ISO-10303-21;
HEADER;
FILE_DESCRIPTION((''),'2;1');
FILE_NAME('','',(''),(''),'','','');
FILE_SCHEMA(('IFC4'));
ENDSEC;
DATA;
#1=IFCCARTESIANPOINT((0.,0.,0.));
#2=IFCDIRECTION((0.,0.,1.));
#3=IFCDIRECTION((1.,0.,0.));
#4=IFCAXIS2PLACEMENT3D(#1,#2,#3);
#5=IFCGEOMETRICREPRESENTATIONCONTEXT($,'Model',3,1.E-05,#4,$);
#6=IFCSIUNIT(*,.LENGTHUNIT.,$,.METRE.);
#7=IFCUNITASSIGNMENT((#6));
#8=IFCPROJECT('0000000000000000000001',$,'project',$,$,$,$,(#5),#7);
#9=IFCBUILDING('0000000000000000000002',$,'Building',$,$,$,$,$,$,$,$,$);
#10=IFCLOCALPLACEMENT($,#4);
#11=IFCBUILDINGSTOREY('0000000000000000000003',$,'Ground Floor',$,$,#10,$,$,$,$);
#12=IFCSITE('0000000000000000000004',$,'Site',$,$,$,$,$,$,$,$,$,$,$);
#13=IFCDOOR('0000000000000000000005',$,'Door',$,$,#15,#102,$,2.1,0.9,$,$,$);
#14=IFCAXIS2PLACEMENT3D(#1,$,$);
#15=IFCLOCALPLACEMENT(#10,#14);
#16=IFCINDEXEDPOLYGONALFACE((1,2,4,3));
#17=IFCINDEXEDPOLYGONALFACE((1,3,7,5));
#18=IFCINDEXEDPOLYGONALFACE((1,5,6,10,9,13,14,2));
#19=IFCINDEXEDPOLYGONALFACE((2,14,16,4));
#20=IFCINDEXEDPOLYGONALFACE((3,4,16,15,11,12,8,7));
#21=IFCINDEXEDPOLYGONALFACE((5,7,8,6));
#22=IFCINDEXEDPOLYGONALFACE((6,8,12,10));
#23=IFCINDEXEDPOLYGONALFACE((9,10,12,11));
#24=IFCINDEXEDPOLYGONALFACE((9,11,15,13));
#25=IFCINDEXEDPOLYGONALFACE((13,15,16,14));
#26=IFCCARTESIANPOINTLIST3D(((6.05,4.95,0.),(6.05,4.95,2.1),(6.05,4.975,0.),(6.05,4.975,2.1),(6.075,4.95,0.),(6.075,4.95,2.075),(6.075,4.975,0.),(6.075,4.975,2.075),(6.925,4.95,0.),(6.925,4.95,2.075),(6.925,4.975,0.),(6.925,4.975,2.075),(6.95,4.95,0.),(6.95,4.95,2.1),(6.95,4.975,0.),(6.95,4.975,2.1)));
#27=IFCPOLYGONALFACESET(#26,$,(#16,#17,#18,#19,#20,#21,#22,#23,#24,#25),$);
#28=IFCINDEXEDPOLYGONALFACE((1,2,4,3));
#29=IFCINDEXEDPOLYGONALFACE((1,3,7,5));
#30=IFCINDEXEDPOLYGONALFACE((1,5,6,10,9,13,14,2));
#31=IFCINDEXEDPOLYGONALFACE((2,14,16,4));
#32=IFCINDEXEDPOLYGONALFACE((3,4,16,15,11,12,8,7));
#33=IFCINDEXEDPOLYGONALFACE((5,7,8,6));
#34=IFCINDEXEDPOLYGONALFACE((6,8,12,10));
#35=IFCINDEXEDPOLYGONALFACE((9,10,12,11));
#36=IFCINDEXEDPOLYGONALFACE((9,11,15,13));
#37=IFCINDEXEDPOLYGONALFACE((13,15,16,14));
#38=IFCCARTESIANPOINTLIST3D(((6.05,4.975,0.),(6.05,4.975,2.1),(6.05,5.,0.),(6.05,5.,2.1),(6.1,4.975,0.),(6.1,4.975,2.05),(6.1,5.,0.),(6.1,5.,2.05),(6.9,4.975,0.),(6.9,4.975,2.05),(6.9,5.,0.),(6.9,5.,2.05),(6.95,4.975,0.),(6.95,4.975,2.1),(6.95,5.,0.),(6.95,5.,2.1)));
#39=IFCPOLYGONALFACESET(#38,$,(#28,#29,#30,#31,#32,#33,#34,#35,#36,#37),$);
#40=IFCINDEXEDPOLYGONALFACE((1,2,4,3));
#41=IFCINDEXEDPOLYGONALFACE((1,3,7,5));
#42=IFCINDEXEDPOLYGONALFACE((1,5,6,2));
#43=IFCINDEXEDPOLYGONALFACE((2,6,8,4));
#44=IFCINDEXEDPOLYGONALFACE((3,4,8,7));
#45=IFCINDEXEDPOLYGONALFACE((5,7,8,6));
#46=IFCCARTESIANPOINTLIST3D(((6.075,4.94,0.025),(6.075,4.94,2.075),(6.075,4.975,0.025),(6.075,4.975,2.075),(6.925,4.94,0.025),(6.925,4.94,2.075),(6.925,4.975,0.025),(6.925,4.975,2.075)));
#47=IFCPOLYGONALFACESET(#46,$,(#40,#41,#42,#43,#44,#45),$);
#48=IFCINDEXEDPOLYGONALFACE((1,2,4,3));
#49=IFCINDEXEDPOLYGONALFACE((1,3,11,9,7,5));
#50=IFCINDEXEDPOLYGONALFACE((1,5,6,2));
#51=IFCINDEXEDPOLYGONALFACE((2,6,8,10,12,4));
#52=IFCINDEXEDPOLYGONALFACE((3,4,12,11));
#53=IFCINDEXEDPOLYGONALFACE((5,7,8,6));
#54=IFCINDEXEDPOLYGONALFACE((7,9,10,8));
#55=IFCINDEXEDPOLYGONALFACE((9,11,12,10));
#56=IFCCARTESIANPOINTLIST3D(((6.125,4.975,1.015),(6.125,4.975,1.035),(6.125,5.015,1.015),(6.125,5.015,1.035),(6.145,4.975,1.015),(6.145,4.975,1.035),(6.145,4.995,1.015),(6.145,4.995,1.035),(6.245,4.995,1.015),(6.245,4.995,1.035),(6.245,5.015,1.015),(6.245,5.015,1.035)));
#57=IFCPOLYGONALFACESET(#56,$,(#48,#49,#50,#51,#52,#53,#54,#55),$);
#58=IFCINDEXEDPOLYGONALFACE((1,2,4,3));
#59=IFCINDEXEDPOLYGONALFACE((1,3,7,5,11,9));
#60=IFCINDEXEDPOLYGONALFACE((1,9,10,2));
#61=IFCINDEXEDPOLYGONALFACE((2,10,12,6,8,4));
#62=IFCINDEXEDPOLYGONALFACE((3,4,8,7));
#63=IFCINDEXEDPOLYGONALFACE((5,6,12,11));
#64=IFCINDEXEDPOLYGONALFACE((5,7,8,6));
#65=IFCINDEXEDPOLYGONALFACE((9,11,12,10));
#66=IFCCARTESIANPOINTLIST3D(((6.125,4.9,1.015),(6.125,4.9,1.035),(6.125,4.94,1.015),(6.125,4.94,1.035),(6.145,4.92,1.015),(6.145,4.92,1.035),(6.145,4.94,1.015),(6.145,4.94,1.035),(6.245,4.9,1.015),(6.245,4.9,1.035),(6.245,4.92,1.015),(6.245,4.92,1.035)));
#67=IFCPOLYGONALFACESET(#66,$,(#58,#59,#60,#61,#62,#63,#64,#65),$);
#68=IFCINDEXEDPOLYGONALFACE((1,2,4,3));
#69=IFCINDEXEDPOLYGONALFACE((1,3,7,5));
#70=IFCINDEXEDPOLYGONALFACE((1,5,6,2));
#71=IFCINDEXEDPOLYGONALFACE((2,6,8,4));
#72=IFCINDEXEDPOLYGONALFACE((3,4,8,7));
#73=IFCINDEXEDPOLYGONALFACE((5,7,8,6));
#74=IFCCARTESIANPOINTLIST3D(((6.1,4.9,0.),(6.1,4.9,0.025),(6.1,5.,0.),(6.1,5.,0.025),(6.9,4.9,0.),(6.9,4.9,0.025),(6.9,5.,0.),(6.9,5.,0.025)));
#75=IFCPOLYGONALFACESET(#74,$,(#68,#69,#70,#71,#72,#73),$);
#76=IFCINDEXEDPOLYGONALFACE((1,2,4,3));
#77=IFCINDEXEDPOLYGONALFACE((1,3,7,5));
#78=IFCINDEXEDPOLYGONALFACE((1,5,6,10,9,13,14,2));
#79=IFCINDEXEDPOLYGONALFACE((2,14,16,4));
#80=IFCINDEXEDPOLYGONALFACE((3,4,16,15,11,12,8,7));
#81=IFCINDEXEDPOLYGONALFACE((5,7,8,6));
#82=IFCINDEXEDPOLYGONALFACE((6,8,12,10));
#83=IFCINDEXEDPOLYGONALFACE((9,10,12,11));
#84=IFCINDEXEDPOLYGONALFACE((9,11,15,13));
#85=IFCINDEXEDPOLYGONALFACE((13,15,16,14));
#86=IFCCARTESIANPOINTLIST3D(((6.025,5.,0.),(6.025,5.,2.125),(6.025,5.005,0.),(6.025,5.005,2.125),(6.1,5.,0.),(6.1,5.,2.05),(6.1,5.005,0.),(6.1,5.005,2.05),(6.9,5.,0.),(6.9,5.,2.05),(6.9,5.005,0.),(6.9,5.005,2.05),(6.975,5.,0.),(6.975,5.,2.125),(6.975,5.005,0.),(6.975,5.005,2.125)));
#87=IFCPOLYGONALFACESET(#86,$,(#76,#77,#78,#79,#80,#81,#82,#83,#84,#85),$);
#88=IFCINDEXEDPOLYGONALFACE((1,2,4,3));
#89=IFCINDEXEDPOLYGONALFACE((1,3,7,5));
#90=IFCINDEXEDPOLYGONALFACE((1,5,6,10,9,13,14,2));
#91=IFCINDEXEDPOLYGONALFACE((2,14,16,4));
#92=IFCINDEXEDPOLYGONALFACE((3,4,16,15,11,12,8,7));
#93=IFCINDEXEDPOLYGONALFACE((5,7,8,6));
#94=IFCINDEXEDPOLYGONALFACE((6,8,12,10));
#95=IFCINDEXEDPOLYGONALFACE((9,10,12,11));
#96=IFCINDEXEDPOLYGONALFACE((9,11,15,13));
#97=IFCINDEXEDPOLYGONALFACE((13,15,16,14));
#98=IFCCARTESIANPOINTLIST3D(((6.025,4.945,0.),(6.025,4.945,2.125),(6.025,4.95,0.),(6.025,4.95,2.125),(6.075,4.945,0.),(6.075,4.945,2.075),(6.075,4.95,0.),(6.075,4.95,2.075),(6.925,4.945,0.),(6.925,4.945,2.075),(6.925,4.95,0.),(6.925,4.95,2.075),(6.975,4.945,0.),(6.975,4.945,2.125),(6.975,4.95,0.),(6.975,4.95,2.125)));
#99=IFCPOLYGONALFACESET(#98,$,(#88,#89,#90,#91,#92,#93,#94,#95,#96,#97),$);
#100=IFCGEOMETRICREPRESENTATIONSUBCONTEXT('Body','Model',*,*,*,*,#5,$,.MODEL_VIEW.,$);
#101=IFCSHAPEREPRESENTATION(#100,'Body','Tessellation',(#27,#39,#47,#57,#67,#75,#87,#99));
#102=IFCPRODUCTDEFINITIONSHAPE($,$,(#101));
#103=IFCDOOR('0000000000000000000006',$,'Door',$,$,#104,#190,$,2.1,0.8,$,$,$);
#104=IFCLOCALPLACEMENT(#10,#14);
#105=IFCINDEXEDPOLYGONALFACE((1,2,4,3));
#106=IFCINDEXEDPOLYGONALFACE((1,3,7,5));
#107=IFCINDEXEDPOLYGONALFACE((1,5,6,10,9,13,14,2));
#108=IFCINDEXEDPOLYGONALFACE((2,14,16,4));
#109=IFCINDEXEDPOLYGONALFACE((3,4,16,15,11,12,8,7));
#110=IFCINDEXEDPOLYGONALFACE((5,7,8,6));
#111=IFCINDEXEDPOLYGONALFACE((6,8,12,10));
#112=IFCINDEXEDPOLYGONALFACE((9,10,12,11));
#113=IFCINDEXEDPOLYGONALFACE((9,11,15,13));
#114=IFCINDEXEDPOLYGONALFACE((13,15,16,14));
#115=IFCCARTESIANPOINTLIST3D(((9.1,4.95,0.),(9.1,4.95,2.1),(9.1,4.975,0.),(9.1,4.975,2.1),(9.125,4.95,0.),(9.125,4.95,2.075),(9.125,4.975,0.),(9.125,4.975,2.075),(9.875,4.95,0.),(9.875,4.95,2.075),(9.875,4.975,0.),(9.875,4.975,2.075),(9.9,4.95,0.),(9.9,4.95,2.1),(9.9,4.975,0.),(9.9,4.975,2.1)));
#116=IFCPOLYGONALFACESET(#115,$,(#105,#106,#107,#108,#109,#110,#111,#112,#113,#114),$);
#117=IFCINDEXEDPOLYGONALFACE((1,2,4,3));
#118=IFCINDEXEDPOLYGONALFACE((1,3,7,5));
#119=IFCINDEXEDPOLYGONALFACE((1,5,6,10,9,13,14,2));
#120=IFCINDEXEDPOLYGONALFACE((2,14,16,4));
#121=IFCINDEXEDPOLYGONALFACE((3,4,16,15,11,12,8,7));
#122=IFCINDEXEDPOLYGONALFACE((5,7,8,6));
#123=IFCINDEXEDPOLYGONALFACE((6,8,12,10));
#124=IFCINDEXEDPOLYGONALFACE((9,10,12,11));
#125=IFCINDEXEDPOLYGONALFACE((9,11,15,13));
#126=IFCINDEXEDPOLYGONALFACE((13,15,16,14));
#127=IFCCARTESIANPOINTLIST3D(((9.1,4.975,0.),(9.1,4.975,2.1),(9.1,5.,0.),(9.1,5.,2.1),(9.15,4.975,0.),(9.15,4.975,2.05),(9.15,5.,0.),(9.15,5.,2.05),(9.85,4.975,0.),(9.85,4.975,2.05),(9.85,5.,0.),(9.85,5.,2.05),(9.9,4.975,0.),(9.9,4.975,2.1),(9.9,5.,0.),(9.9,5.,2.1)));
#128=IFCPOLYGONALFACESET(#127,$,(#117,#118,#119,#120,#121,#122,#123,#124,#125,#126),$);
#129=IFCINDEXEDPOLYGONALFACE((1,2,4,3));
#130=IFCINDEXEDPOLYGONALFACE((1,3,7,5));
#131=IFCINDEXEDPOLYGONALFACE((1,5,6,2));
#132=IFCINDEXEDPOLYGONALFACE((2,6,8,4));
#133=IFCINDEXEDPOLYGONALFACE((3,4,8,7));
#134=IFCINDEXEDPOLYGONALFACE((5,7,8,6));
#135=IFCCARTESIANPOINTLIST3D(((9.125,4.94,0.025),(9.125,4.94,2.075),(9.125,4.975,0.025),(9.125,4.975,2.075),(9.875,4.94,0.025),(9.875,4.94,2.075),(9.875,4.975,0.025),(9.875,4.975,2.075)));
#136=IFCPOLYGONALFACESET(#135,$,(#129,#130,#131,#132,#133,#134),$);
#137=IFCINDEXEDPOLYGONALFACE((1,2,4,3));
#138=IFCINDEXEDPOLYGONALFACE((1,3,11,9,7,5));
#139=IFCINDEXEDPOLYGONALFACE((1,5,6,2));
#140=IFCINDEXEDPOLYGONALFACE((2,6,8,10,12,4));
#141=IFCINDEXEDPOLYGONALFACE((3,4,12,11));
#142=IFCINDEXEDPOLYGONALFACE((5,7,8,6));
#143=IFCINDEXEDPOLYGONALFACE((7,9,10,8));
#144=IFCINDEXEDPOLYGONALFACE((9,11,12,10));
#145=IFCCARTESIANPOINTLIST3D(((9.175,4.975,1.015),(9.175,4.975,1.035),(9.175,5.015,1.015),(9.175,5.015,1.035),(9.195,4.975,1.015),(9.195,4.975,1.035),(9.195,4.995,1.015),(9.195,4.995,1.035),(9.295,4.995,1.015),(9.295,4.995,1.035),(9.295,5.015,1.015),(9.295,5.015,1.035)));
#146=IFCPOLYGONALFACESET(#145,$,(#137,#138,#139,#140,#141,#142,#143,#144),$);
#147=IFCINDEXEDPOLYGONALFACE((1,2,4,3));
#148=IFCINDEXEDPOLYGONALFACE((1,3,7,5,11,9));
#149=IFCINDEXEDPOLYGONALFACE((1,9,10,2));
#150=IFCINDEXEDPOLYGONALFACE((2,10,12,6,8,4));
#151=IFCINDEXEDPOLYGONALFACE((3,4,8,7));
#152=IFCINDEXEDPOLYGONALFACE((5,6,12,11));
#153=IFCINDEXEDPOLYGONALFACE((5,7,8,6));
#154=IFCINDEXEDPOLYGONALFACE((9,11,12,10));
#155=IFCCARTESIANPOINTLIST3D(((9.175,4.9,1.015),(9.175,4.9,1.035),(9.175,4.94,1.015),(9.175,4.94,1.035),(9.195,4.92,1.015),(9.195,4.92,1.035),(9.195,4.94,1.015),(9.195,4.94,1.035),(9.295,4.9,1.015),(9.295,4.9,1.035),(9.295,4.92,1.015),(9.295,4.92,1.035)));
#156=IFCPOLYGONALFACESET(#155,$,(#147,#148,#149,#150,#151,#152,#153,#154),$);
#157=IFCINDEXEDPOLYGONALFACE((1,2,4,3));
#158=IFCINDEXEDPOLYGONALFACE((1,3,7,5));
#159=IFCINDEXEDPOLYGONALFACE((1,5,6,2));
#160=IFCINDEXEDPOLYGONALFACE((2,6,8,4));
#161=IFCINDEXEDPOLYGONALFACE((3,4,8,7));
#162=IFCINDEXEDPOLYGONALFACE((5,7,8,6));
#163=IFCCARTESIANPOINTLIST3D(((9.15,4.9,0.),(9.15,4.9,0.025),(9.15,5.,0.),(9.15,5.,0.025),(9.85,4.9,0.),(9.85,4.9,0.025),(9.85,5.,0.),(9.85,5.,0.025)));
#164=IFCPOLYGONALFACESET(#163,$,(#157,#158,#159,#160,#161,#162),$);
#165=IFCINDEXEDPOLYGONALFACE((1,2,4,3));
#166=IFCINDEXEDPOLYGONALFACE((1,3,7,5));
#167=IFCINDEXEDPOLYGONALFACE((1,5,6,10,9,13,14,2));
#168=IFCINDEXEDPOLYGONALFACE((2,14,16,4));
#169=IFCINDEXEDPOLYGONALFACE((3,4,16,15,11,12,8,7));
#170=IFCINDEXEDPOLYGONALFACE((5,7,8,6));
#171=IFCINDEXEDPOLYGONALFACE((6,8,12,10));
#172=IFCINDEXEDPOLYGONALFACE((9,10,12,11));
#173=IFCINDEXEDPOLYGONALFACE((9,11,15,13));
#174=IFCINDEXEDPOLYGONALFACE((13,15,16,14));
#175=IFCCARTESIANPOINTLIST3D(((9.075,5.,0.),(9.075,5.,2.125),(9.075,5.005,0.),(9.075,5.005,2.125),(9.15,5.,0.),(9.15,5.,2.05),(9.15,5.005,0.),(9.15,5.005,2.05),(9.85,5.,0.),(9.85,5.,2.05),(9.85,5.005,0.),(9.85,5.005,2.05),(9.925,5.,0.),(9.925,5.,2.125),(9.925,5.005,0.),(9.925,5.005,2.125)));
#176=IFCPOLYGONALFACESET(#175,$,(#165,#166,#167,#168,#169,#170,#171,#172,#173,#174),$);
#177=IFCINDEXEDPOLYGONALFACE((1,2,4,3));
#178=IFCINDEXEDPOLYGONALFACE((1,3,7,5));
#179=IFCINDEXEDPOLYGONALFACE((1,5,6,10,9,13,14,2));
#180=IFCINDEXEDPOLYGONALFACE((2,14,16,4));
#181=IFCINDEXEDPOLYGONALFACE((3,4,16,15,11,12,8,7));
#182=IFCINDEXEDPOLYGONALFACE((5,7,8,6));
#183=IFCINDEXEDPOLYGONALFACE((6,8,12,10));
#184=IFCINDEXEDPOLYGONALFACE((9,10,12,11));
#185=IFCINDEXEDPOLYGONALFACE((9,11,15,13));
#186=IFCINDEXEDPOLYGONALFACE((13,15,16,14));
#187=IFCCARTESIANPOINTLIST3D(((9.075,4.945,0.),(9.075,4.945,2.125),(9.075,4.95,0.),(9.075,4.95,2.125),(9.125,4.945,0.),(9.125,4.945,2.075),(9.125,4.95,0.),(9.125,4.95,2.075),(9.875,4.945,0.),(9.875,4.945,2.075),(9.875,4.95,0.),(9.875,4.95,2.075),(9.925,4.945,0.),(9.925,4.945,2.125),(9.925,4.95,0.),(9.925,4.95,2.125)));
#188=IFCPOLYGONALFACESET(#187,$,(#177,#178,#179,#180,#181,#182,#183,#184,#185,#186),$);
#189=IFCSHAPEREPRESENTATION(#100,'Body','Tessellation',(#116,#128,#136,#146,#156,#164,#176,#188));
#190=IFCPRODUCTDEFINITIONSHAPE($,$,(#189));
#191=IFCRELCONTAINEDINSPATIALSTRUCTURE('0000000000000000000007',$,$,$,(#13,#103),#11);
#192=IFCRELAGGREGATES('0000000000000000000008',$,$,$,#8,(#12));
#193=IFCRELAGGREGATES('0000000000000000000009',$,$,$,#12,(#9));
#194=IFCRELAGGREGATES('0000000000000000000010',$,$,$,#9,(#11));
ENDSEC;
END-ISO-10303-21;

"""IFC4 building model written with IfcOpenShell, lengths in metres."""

from ifc_helpers import new_model, si_unit, frame, origin_with_axes, place, context, subcontext, project, spatial, line, indexed_curve, outline, extrude, element, save


model = new_model("IFC4")

# Units and contexts
model_context = context("Model", 3, precision=1e-05, world=origin_with_axes())
body_context = subcontext(model_context, "Body", "Model", "MODEL_VIEW")
ifc_project = project(units=[si_unit("LENGTHUNIT", "METRE")], contexts=[model_context])

# Site, building, storey
site = spatial("IfcSite", under=ifc_project, Name="Site")
building = spatial("IfcBuilding", under=site, Name="Building")
storey_placement = place(None, origin_with_axes())
storey = spatial("IfcBuildingStorey", under=building, at=storey_placement, Name="Ground Floor")

# Doors
door_1_placement = place(storey_placement, frame((6.95, 5.0, 0.0), z_axis=(0.0, 0.0, 1.0), x_axis=(-1.0, 0.0, 0.0)))
element("IfcDoor", 1, at=door_1_placement, inside=storey, Name="Door", OverallHeight=2.1, OverallWidth=0.9, context=body_context, shape_type="SweptSolid", body=[
    extrude(outline(indexed_curve([(0.0, 0.0), (0.0, 2.1), (0.9, 2.1), (0.9, 0.0), (0.875, 0.0), (0.875, 2.075), (0.025, 2.075), (0.025, 0.0)], segments=[line(1, 2, 3, 4, 5, 6, 7, 8, 1)])), frame((0.0, 0.025, 0.0), z_axis=(0.0, -1.0, 0.0), x_axis=(1.0, 0.0, 0.0)), (0.0, 0.0, -1.0), 0.025),
    extrude(outline(indexed_curve([(0.0, 0.0), (0.0, 2.1), (0.9, 2.1), (0.9, 0.0), (0.85, 0.0), (0.85, 2.05), (0.05, 2.05), (0.05, 0.0)], segments=[line(1, 2, 3, 4, 5, 6, 7, 8, 1)])), frame((0.0, 0.0, 0.0), z_axis=(0.0, -1.0, 0.0), x_axis=(1.0, 0.0, 0.0)), (0.0, 0.0, -1.0), 0.025),
    extrude(outline(indexed_curve([(0.0, 0.0), (0.85, 0.0), (0.85, 0.035), (0.0, 0.035)], segments=[line(1, 2, 3, 4, 1)])), frame((0.025, 0.025, 0.025), z_axis=(0.0, 0.0, 1.0), x_axis=(1.0, 0.0, 0.0)), (0.0, 0.0, 1.0), 2.05),
    extrude(outline(indexed_curve([(0.0, 0.0), (0.0, -0.04), (-0.12, -0.04), (-0.12, -0.02), (-0.02, -0.02), (-0.02, 0.0)], segments=[line(1, 2, 3, 4, 5, 6, 1)])), frame((0.825, 0.025, 1.015), z_axis=(0.0, 0.0, 1.0), x_axis=(1.0, 0.0, 0.0)), (0.0, 0.0, 1.0), 0.02),
    extrude(outline(indexed_curve([(0.0, 0.0), (0.0, 0.04), (-0.12, 0.04), (-0.12, 0.02), (-0.02, 0.02), (-0.02, 0.0)], segments=[line(1, 2, 3, 4, 5, 6, 1)])), frame((0.825, 0.06, 1.015), z_axis=(0.0, 0.0, 1.0), x_axis=(1.0, 0.0, 0.0)), (0.0, 0.0, 1.0), 0.02),
    extrude(outline(indexed_curve([(0.0, 0.0), (0.8, 0.0), (0.8, 0.1), (0.0, 0.1)], segments=[line(1, 2, 3, 4, 1)])), frame((0.05, 0.0, 0.0), z_axis=(0.0, 0.0, 1.0), x_axis=(1.0, 0.0, 0.0)), (0.0, 0.0, 1.0), 0.025),
    extrude(outline(indexed_curve([(0.0, 0.0), (0.0, 2.125), (0.95, 2.125), (0.95, 0.0), (0.875, 0.0), (0.875, 2.05), (0.075, 2.05), (0.075, 0.0)], segments=[line(1, 2, 3, 4, 5, 6, 7, 8, 1)])), frame((-0.025, -0.005, 0.0), z_axis=(0.0, -1.0, 0.0), x_axis=(1.0, 0.0, 0.0)), (0.0, 0.0, -1.0), 0.005),
    extrude(outline(indexed_curve([(0.0, 0.0), (0.0, 2.125), (0.95, 2.125), (0.95, 0.0), (0.9, 0.0), (0.9, 2.075), (0.05, 2.075), (0.05, 0.0)], segments=[line(1, 2, 3, 4, 5, 6, 7, 8, 1)])), frame((-0.025, 0.05, 0.0), z_axis=(0.0, -1.0, 0.0), x_axis=(1.0, 0.0, 0.0)), (0.0, 0.0, -1.0), 0.005),
])
door_2_placement = place(storey_placement, frame((9.9, 5.0, 0.0), z_axis=(0.0, 0.0, 1.0), x_axis=(-1.0, 0.0, 0.0)))
element("IfcDoor", 2, at=door_2_placement, inside=storey, Name="Door", OverallHeight=2.1, OverallWidth=0.8, context=body_context, shape_type="SweptSolid", body=[
    extrude(outline(indexed_curve([(0.0, 0.0), (0.0, 2.1), (0.8, 2.1), (0.8, 0.0), (0.775, 0.0), (0.775, 2.075), (0.025, 2.075), (0.025, 0.0)], segments=[line(1, 2, 3, 4, 5, 6, 7, 8, 1)])), frame((0.0, 0.025, 0.0), z_axis=(0.0, -1.0, 0.0), x_axis=(1.0, 0.0, 0.0)), (0.0, 0.0, -1.0), 0.025),
    extrude(outline(indexed_curve([(0.0, 0.0), (0.0, 2.1), (0.8, 2.1), (0.8, 0.0), (0.75, 0.0), (0.75, 2.05), (0.05, 2.05), (0.05, 0.0)], segments=[line(1, 2, 3, 4, 5, 6, 7, 8, 1)])), frame((0.0, 0.0, 0.0), z_axis=(0.0, -1.0, 0.0), x_axis=(1.0, 0.0, 0.0)), (0.0, 0.0, -1.0), 0.025),
    extrude(outline(indexed_curve([(0.0, 0.0), (0.75, 0.0), (0.75, 0.035), (0.0, 0.035)], segments=[line(1, 2, 3, 4, 1)])), frame((0.025, 0.025, 0.025), z_axis=(0.0, 0.0, 1.0), x_axis=(1.0, 0.0, 0.0)), (0.0, 0.0, 1.0), 2.05),
    extrude(outline(indexed_curve([(0.0, 0.0), (0.0, -0.04), (-0.12, -0.04), (-0.12, -0.02), (-0.02, -0.02), (-0.02, 0.0)], segments=[line(1, 2, 3, 4, 5, 6, 1)])), frame((0.725, 0.025, 1.015), z_axis=(0.0, 0.0, 1.0), x_axis=(1.0, 0.0, 0.0)), (0.0, 0.0, 1.0), 0.02),
    extrude(outline(indexed_curve([(0.0, 0.0), (0.0, 0.04), (-0.12, 0.04), (-0.12, 0.02), (-0.02, 0.02), (-0.02, 0.0)], segments=[line(1, 2, 3, 4, 5, 6, 1)])), frame((0.725, 0.06, 1.015), z_axis=(0.0, 0.0, 1.0), x_axis=(1.0, 0.0, 0.0)), (0.0, 0.0, 1.0), 0.02),
    extrude(outline(indexed_curve([(0.0, 0.0), (0.7, 0.0), (0.7, 0.1), (0.0, 0.1)], segments=[line(1, 2, 3, 4, 1)])), frame((0.05, 0.0, 0.0), z_axis=(0.0, 0.0, 1.0), x_axis=(1.0, 0.0, 0.0)), (0.0, 0.0, 1.0), 0.025),
    extrude(outline(indexed_curve([(0.0, 0.0), (0.0, 2.125), (0.85, 2.125), (0.85, 0.0), (0.775, 0.0), (0.775, 2.05), (0.075, 2.05), (0.075, 0.0)], segments=[line(1, 2, 3, 4, 5, 6, 7, 8, 1)])), frame((-0.025, -0.005, 0.0), z_axis=(0.0, -1.0, 0.0), x_axis=(1.0, 0.0, 0.0)), (0.0, 0.0, -1.0), 0.005),
    extrude(outline(indexed_curve([(0.0, 0.0), (0.0, 2.125), (0.85, 2.125), (0.85, 0.0), (0.8, 0.0), (0.8, 2.075), (0.05, 2.075), (0.05, 0.0)], segments=[line(1, 2, 3, 4, 5, 6, 7, 8, 1)])), frame((-0.025, 0.05, 0.0), z_axis=(0.0, -1.0, 0.0), x_axis=(1.0, 0.0, 0.0)), (0.0, 0.0, -1.0), 0.005),
])

save(model, "model.ifc")
